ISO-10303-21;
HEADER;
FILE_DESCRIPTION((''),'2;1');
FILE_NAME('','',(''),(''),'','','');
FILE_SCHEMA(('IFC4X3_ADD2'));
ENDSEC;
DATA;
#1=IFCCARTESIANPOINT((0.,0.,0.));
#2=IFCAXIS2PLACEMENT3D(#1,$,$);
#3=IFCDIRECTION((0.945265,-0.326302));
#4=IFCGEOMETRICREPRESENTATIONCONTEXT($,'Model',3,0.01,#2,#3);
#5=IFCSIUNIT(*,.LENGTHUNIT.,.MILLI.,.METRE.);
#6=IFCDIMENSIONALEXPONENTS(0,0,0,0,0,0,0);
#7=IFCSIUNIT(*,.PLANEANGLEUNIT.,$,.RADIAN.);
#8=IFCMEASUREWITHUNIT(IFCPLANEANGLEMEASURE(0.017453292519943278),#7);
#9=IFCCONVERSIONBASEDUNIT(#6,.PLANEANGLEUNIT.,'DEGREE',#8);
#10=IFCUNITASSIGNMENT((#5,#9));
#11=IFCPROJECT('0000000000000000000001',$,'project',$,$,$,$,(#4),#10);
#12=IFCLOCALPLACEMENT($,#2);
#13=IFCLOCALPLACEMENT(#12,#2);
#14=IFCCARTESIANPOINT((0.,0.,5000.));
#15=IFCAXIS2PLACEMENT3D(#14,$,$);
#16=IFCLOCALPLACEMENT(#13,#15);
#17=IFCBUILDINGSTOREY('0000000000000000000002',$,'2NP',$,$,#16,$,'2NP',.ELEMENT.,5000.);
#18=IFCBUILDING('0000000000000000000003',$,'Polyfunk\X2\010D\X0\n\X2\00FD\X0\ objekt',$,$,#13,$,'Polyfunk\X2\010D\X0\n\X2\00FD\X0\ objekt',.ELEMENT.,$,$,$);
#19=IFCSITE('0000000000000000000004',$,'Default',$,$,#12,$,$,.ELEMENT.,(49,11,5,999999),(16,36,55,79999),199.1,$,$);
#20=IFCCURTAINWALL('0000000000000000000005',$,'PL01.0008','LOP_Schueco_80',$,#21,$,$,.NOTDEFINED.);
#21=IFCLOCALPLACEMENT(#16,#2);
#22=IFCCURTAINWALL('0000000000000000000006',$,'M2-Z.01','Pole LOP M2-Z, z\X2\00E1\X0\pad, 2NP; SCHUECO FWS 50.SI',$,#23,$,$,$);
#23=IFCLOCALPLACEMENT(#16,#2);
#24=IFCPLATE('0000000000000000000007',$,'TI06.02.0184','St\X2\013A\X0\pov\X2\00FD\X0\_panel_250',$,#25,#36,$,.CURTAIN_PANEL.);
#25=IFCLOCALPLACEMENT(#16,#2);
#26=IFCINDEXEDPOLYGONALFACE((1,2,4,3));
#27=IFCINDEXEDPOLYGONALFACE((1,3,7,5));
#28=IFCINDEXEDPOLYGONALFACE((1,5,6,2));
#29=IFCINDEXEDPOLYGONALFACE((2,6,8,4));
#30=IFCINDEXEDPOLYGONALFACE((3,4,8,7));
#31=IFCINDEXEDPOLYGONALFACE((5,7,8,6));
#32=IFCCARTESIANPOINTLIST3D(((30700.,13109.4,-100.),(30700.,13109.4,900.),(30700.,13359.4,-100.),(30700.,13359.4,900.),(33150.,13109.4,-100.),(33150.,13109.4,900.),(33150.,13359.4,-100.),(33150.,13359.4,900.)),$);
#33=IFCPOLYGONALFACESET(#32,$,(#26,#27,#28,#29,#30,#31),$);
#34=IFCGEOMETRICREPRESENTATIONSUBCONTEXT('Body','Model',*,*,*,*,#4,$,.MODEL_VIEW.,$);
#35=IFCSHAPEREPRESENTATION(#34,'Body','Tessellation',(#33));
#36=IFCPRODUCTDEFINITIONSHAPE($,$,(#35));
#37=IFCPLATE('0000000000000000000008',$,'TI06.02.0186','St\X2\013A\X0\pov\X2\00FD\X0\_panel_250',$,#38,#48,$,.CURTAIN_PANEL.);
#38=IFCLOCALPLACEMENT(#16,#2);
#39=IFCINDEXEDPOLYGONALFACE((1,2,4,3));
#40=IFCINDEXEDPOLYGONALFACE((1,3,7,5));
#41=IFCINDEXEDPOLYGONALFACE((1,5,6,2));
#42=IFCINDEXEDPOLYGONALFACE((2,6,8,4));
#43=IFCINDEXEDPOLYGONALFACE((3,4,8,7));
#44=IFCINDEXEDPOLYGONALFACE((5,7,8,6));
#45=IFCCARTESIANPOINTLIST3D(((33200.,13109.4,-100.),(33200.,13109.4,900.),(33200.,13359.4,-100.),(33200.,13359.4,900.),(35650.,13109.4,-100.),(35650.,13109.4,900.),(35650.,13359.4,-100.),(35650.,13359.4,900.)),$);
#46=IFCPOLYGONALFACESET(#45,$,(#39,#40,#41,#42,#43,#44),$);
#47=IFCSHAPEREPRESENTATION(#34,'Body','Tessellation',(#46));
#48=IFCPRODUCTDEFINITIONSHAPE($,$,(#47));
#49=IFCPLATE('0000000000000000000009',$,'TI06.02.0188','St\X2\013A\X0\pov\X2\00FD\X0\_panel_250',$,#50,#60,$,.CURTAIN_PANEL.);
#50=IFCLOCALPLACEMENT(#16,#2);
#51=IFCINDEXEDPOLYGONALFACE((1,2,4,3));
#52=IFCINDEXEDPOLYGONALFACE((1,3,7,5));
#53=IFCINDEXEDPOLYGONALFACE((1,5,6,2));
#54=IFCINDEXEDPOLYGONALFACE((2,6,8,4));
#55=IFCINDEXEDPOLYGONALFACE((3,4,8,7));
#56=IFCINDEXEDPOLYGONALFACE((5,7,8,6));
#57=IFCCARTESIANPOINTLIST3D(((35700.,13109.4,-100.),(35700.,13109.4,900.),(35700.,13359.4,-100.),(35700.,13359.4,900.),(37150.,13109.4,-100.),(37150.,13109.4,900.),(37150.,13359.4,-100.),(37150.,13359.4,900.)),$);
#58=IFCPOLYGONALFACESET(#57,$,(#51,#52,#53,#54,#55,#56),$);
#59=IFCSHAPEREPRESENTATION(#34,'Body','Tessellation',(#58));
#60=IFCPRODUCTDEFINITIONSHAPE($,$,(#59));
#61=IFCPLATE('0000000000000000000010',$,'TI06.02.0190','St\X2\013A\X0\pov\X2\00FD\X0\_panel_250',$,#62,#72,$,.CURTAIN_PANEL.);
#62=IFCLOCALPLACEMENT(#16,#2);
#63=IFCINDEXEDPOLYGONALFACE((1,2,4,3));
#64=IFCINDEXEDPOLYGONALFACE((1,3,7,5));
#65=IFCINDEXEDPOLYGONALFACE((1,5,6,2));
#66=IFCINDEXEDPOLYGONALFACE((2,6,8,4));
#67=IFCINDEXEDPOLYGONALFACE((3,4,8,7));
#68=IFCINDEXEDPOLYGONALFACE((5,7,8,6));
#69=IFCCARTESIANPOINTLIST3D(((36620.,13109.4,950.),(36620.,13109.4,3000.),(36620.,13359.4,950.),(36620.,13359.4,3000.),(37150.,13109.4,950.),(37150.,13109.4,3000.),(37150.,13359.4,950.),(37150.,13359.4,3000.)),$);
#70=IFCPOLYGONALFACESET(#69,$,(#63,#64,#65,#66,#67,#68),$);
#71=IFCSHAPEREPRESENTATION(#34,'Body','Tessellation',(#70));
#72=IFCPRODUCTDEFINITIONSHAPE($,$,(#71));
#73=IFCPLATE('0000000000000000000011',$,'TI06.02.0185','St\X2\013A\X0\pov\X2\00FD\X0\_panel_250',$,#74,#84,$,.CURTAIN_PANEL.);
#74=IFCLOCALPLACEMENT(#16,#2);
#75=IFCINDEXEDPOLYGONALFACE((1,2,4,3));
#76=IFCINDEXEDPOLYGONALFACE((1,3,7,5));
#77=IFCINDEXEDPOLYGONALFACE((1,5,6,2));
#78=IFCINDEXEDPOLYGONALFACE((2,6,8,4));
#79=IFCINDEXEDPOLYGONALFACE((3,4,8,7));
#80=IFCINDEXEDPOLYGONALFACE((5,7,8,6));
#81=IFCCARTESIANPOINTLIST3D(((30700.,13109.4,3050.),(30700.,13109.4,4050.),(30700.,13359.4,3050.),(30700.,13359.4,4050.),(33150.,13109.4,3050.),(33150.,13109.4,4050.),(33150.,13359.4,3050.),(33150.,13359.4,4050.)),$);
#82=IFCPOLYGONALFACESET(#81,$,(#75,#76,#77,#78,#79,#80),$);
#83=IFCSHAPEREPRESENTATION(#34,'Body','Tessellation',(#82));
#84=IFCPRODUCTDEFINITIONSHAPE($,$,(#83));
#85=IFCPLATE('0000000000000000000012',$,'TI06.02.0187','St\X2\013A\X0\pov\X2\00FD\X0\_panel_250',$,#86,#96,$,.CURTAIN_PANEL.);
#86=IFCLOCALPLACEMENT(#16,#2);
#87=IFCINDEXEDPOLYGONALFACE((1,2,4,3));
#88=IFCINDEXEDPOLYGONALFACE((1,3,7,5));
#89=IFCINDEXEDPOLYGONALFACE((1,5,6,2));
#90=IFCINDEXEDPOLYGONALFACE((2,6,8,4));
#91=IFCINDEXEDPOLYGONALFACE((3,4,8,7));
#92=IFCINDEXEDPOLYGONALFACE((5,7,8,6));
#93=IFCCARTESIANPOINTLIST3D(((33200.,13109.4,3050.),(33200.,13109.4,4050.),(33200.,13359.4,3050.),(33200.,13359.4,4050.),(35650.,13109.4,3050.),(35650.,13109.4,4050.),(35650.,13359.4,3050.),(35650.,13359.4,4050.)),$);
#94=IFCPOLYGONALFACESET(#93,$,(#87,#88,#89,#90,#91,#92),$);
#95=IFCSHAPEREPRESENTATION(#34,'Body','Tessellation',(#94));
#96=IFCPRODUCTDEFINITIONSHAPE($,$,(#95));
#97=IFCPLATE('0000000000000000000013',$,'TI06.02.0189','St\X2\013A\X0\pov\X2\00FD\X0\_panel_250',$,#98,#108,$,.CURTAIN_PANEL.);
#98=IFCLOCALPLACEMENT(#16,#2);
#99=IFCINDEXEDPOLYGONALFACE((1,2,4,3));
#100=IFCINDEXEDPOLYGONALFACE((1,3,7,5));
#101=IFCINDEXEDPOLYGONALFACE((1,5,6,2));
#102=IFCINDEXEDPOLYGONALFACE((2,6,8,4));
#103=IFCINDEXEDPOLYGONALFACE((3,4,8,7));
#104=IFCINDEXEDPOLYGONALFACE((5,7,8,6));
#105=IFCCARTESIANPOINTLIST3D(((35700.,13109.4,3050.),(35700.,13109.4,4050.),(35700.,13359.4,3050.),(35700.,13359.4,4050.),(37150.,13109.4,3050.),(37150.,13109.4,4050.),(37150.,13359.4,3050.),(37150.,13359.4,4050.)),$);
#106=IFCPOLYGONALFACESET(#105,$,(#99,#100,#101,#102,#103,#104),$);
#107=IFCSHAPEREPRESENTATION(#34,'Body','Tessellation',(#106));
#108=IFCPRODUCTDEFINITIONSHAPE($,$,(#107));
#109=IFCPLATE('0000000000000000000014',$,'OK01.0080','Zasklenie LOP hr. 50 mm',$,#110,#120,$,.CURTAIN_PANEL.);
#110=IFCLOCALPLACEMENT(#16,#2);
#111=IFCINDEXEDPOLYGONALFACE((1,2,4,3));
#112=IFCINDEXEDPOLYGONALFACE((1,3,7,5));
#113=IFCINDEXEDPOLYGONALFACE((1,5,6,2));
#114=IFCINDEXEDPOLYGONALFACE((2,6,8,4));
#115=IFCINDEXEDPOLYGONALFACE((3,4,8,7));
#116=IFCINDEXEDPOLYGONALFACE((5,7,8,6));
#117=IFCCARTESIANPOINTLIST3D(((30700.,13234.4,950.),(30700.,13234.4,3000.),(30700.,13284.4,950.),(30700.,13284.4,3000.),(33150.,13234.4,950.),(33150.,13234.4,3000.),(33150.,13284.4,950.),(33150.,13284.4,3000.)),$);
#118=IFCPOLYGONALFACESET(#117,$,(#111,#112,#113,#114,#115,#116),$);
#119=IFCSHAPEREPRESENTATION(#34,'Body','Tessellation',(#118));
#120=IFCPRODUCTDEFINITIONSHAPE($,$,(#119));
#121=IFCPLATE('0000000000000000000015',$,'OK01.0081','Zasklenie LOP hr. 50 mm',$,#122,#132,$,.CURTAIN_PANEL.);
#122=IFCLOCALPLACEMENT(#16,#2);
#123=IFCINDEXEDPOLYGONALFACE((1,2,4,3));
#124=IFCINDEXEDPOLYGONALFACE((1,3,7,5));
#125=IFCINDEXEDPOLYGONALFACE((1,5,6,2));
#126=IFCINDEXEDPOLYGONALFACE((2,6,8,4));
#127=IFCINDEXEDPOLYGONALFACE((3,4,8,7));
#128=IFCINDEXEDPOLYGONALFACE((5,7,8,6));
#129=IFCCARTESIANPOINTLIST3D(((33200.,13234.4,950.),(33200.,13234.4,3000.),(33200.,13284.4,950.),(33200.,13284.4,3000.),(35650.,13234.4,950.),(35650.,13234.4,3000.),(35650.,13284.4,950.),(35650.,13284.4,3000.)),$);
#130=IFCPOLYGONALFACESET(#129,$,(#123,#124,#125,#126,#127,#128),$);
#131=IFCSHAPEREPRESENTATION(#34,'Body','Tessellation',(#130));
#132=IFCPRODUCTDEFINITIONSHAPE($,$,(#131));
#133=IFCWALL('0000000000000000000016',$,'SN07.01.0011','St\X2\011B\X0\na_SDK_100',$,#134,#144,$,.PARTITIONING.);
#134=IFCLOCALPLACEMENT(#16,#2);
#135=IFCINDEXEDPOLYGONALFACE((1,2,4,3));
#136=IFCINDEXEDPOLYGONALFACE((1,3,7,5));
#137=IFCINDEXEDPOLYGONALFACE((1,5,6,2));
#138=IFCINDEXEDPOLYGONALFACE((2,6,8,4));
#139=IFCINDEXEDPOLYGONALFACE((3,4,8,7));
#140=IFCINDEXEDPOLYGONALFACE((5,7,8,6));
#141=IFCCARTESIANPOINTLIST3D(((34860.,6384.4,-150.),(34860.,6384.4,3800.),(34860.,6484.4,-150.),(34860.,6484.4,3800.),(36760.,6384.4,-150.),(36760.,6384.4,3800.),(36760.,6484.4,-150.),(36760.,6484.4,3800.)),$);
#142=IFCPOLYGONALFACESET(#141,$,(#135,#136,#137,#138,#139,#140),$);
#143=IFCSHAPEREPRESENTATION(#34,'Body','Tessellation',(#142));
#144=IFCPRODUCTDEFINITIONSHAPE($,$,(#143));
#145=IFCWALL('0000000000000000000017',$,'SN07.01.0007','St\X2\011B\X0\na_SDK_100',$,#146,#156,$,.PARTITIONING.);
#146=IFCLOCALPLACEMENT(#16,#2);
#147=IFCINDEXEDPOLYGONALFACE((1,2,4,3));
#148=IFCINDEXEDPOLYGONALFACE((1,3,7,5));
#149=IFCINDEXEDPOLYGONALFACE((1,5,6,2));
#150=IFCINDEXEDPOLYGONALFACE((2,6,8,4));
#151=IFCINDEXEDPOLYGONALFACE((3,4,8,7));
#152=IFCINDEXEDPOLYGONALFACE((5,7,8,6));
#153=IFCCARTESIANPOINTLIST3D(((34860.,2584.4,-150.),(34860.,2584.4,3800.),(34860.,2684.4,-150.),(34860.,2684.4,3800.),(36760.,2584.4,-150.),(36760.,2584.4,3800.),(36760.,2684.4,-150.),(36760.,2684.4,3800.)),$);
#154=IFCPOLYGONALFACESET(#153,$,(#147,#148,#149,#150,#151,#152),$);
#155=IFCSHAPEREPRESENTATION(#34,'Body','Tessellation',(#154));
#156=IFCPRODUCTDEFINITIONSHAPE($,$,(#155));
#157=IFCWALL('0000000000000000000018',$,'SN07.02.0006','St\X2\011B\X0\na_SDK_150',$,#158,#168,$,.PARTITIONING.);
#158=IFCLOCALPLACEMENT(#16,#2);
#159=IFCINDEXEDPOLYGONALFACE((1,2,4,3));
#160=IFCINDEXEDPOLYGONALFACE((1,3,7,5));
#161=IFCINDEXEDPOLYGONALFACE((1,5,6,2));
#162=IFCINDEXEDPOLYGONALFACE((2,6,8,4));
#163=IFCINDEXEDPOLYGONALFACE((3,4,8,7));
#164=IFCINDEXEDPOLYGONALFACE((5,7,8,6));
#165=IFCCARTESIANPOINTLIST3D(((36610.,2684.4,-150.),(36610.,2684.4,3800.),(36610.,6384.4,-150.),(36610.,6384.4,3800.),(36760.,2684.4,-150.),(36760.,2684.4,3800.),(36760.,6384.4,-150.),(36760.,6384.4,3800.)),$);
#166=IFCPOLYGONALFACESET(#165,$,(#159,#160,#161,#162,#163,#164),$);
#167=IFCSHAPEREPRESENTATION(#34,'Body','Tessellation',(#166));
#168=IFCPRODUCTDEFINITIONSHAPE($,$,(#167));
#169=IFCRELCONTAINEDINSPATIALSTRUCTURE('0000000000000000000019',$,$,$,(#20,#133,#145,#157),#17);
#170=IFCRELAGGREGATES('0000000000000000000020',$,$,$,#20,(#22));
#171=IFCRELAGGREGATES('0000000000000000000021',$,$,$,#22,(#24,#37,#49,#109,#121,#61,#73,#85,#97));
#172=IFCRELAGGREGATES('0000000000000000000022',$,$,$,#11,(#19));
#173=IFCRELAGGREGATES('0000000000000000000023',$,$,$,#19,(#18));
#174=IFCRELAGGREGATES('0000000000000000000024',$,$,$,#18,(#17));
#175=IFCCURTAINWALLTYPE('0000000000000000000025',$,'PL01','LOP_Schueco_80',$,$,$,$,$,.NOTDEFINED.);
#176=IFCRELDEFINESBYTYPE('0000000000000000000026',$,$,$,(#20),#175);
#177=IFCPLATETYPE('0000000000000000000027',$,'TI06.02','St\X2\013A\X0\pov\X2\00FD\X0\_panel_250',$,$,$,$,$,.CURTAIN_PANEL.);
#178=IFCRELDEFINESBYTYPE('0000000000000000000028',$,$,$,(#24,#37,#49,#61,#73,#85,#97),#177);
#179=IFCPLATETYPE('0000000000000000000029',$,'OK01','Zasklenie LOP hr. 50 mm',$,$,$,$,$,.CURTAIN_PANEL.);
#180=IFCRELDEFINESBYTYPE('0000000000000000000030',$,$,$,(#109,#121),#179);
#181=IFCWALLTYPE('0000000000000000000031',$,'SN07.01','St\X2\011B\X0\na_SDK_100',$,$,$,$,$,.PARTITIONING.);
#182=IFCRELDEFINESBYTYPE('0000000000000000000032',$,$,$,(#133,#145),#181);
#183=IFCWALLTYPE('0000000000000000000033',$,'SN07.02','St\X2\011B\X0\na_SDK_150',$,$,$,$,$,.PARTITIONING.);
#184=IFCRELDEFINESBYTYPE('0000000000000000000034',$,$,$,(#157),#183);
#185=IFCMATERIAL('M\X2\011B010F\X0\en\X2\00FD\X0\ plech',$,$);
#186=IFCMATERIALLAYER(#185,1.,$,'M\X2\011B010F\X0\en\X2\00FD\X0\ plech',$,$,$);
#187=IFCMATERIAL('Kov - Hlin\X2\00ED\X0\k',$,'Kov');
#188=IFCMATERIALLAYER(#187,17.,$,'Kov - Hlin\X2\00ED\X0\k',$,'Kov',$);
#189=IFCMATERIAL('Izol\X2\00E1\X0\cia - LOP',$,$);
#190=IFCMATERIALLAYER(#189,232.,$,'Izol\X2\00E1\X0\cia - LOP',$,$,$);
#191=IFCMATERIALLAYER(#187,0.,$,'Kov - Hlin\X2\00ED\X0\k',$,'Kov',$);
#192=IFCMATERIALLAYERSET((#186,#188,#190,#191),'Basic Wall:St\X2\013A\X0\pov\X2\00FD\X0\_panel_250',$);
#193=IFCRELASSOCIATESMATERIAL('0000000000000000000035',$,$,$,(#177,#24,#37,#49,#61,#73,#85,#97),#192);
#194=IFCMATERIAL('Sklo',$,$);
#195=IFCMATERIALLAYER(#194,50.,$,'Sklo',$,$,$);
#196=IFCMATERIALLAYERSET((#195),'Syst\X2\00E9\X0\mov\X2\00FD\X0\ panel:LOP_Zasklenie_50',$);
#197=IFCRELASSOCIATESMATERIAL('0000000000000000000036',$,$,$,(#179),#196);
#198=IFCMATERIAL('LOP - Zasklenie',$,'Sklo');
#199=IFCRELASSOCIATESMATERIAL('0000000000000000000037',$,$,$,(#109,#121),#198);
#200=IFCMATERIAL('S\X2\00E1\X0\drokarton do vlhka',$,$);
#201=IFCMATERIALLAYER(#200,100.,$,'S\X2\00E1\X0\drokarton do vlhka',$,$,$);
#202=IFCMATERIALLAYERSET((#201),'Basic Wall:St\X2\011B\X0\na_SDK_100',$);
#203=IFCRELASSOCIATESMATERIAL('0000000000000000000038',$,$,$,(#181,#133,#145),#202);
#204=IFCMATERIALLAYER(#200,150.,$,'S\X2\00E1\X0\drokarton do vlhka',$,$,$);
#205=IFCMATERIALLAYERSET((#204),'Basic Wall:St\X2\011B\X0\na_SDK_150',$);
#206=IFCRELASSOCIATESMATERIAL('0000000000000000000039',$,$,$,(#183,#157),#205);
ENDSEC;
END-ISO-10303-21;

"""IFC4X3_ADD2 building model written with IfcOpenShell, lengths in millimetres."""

from ifc_helpers import new_model, entity, si_unit, converted_unit, direction, frame, frame_2d, origin, origin_2d_with_axis, place, context, subcontext, project, spatial, polyline, rectangle, extrude, clip, bounded_halfspace, source, transform, mapped, material, layer, layer_set, layer_usage, type_object, type_shapes, element, aggregate, save


model = new_model("IFC4X3_ADD2")

# Units and contexts
model_context = context("Model", 3, precision=0.01, world=origin(), true_north=direction((0.945265, -0.326302)))
body_context = subcontext(model_context, "Body", "Model", "MODEL_VIEW")
ifc_project = project(units=[si_unit("LENGTHUNIT", "METRE", prefix="MILLI"), converted_unit("PLANEANGLEUNIT", "DEGREE", entity("IfcPlaneAngleMeasure", 0.017453292519943278), si_unit("PLANEANGLEUNIT", "RADIAN"), dimensions=[0, 0, 0, 0, 0, 0, 0])], contexts=[model_context])

# Site, building, storey
site_placement = place(None, origin())
site = spatial("IfcSite", under=ifc_project, at=site_placement, Name="Default", CompositionType="ELEMENT", RefLatitude=(49, 11, 5, 999999), RefLongitude=(16, 36, 55, 79999), RefElevation=199.1)
building_placement = place(site_placement, origin())
building = spatial("IfcBuilding", under=site, at=building_placement, Name="Polyfunkčný objekt", LongName="Polyfunkčný objekt", CompositionType="ELEMENT")
storey_placement = place(building_placement, frame((0.0, 0.0, 5000.0)))
storey = spatial("IfcBuildingStorey", under=building, at=storey_placement, Name="2NP", LongName="2NP", CompositionType="ELEMENT", Elevation=5000.0)

# Curtain walls, plates
curtain_wall_type = type_object("IfcCurtainWallType", Name="PL01", Description="LOP_Schueco_80", PredefinedType="NOTDEFINED")
curtain_wall_1_placement = place(storey_placement, frame((0.0, 0.0, -5000.0)))
curtain_wall_1 = element("IfcCurtainWall", 1, at=curtain_wall_1_placement, inside=storey, type_object=curtain_wall_type, Name="PL01.0008", Description="LOP_Schueco_80", PredefinedType="NOTDEFINED")
curtain_wall_2 = element("IfcCurtainWall", 2, Name="M2-Z.01", Description="Pole LOP M2-Z, západ, 2NP; SCHUECO FWS 50.SI")
aggregate(curtain_wall_1, [curtain_wall_2])
ifc_material_1 = material(Name="Měďený plech")
ifc_layer_1 = layer(ifc_material_1, 1.0, Name="Měďený plech")
ifc_material_2 = material(Name="Kov - Hliník", Category="Kov")
ifc_layer_2 = layer(ifc_material_2, 17.0, Name="Kov - Hliník", Category="Kov")
ifc_material_3 = material(Name="Izolácia - LOP")
ifc_layer_3 = layer(ifc_material_3, 232.0, Name="Izolácia - LOP")
ifc_layer_4 = layer(ifc_material_2, 0.0, Name="Kov - Hliník", Category="Kov")
ifc_layer_set_1 = layer_set([ifc_layer_1, ifc_layer_2, ifc_layer_3, ifc_layer_4], Name="Basic Wall:Stĺpový_panel_250")
ifc_layer_usage_1 = layer_usage(ifc_layer_set_1, "AXIS2", "NEGATIVE", 125.0)
plate_type_1 = type_object("IfcPlateType", Name="TI06.02", Description="Stĺpový_panel_250", PredefinedType="CURTAIN_PANEL", material=ifc_layer_set_1)
plate_1_placement = place(storey_placement, frame((30700.0, 13234.4, -100.0)))
plate_1 = element("IfcPlate", 3, at=plate_1_placement, type_object=plate_type_1, material=ifc_layer_usage_1, Name="TI06.02.0184", Description="Stĺpový_panel_250", PredefinedType="CURTAIN_PANEL", context=body_context, shape_type="SweptSolid", body=[
    extrude(rectangle(XDim=250.0, YDim=2450.0, at=frame_2d((0.0, 0.0), x_axis=(1.0, 0.0))), frame((1225.0, 0.0, 0.0), z_axis=(0.0, 0.0, 1.0), x_axis=(0.0, 1.0, 0.0)), (0.0, 0.0, 1.0), 1000.0),
])
ifc_layer_usage_2 = layer_usage(ifc_layer_set_1, "AXIS2", "NEGATIVE", 125.0)
plate_2_placement = place(storey_placement, frame((33200.0, 13234.4, -100.0)))
plate_2 = element("IfcPlate", 4, at=plate_2_placement, type_object=plate_type_1, material=ifc_layer_usage_2, Name="TI06.02.0186", Description="Stĺpový_panel_250", PredefinedType="CURTAIN_PANEL", context=body_context, shape_type="SweptSolid", body=[
    extrude(rectangle(XDim=250.0, YDim=2450.0, at=frame_2d((0.0, 0.0), x_axis=(1.0, 0.0))), frame((1225.0, 0.0, 0.0), z_axis=(0.0, 0.0, 1.0), x_axis=(0.0, 1.0, 0.0)), (0.0, 0.0, 1.0), 1000.0),
])
ifc_layer_usage_3 = layer_usage(ifc_layer_set_1, "AXIS2", "NEGATIVE", 125.0)
plate_3_placement = place(storey_placement, frame((35700.0, 13234.4, -100.0)))
plate_3 = element("IfcPlate", 5, at=plate_3_placement, type_object=plate_type_1, material=ifc_layer_usage_3, Name="TI06.02.0188", Description="Stĺpový_panel_250", PredefinedType="CURTAIN_PANEL", context=body_context, shape_type="SweptSolid", body=[
    extrude(rectangle(XDim=250.0, YDim=1450.0, at=origin_2d_with_axis()), frame((725.0, 0.0, 0.0), z_axis=(0.0, 0.0, 1.0), x_axis=(0.0, 1.0, 0.0)), (0.0, 0.0, 1.0), 1000.0),
])
ifc_layer_usage_4 = layer_usage(ifc_layer_set_1, "AXIS2", "NEGATIVE", 125.0)
plate_4_placement = place(storey_placement, frame((36620.0, 13234.4, 950.0)))
plate_4 = element("IfcPlate", 6, at=plate_4_placement, type_object=plate_type_1, material=ifc_layer_usage_4, Name="TI06.02.0190", Description="Stĺpový_panel_250", PredefinedType="CURTAIN_PANEL", context=body_context, shape_type="SweptSolid", body=[
    extrude(rectangle(XDim=250.0, YDim=530.0, at=frame_2d((0.0, 0.0), x_axis=(1.0, 0.0))), frame((265.0, 0.0, 0.0), z_axis=(0.0, 0.0, 1.0), x_axis=(0.0, 1.0, 0.0)), (0.0, 0.0, 1.0), 2050.0),
])
ifc_layer_usage_5 = layer_usage(ifc_layer_set_1, "AXIS2", "NEGATIVE", 125.0)
plate_5_placement = place(storey_placement, frame((30700.0, 13234.4, 3050.0)))
plate_5 = element("IfcPlate", 7, at=plate_5_placement, type_object=plate_type_1, material=ifc_layer_usage_5, Name="TI06.02.0185", Description="Stĺpový_panel_250", PredefinedType="CURTAIN_PANEL", context=body_context, shape_type="SweptSolid", body=[
    extrude(rectangle(XDim=250.0, YDim=2450.0, at=frame_2d((0.0, 0.0), x_axis=(1.0, 0.0))), frame((1225.0, 0.0, 0.0), z_axis=(0.0, 0.0, 1.0), x_axis=(0.0, 1.0, 0.0)), (0.0, 0.0, 1.0), 1000.0),
])
ifc_layer_usage_6 = layer_usage(ifc_layer_set_1, "AXIS2", "NEGATIVE", 125.0)
plate_6_placement = place(storey_placement, frame((33200.0, 13234.4, 3050.0)))
plate_6 = element("IfcPlate", 8, at=plate_6_placement, type_object=plate_type_1, material=ifc_layer_usage_6, Name="TI06.02.0187", Description="Stĺpový_panel_250", PredefinedType="CURTAIN_PANEL", context=body_context, shape_type="SweptSolid", body=[
    extrude(rectangle(XDim=250.0, YDim=2450.0, at=frame_2d((0.0, 0.0), x_axis=(1.0, 0.0))), frame((1225.0, 0.0, 0.0), z_axis=(0.0, 0.0, 1.0), x_axis=(0.0, 1.0, 0.0)), (0.0, 0.0, 1.0), 1000.0),
])
ifc_layer_usage_7 = layer_usage(ifc_layer_set_1, "AXIS2", "NEGATIVE", 125.0)
plate_7_placement = place(storey_placement, frame((35700.0, 13234.4, 3050.0)))
plate_7 = element("IfcPlate", 9, at=plate_7_placement, type_object=plate_type_1, material=ifc_layer_usage_7, Name="TI06.02.0189", Description="Stĺpový_panel_250", PredefinedType="CURTAIN_PANEL", context=body_context, shape_type="SweptSolid", body=[
    extrude(rectangle(XDim=250.0, YDim=1450.0, at=origin_2d_with_axis()), frame((725.0, 0.0, 0.0), z_axis=(0.0, 0.0, 1.0), x_axis=(0.0, 1.0, 0.0)), (0.0, 0.0, 1.0), 1000.0),
])
ifc_material_4 = material(Name="LOP - Zasklenie", Category="Sklo")
ifc_material_5 = material(Name="Sklo")
ifc_layer_5 = layer(ifc_material_5, 50.0, Name="Sklo")
ifc_layer_set_2 = layer_set([ifc_layer_5], Name="Systémový panel:LOP_Zasklenie_50")
plate_type_2 = type_object("IfcPlateType", Name="OK01", Description="Zasklenie LOP hr. 50 mm", PredefinedType="CURTAIN_PANEL", material=ifc_layer_set_2)
shared_shape_1 = source(origin(), body_context, "Body", "SweptSolid", [
    extrude(rectangle(XDim=50.0, YDim=2450.0, at=origin_2d_with_axis()), frame((0.0, 25.0, 0.0), z_axis=(0.0, 0.0, 1.0), x_axis=(0.0, 1.0, 0.0)), (0.0, 0.0, 1.0), 2050.0),
])
type_shapes(plate_type_2, [shared_shape_1])
plate_8_placement = place(curtain_wall_1_placement, frame((31925.0, 13234.4, 5950.0)))
plate_8 = element("IfcPlate", 10, at=plate_8_placement, type_object=plate_type_2, material=ifc_material_4, Name="OK01.0080", Description="Zasklenie LOP hr. 50 mm", PredefinedType="CURTAIN_PANEL", context=body_context, shape_type="MappedRepresentation", body=[
    mapped(shared_shape_1, transform((0.0, 0.0, 0.0), scale=1.0)),
])
plate_9_placement = place(curtain_wall_1_placement, frame((34425.0, 13234.4, 5950.0)))
plate_9 = element("IfcPlate", 11, at=plate_9_placement, type_object=plate_type_2, material=ifc_material_4, Name="OK01.0081", Description="Zasklenie LOP hr. 50 mm", PredefinedType="CURTAIN_PANEL", context=body_context, shape_type="MappedRepresentation", body=[
    mapped(shared_shape_1, transform((0.0, 0.0, 0.0), scale=1.0)),
])

# Walls
ifc_material_6 = material(Name="Sádrokarton do vlhka")
ifc_layer_6 = layer(ifc_material_6, 100.0, Name="Sádrokarton do vlhka")
ifc_layer_set_3 = layer_set([ifc_layer_6], Name="Basic Wall:Stěna_SDK_100")
wall_type_1 = type_object("IfcWallType", Name="SN07.01", Description="Stěna_SDK_100", PredefinedType="PARTITIONING", material=ifc_layer_set_3)
placement = place(building_placement, origin())
wall_1_placement = place(placement, frame((36760.0, 6434.4, 4850.0), z_axis=(0.0, 0.0, 1.0), x_axis=(-1.0, 0.0, 0.0)))
element("IfcWall", 12, at=wall_1_placement, inside=storey, type_object=wall_type_1, material=ifc_layer_set_3, Name="SN07.01.0011", Description="Stěna_SDK_100", PredefinedType="PARTITIONING", context=body_context, shape_type="Clipping", body=[
    clip(clip(extrude(rectangle(XDim=1900.0, YDim=100.0, at=frame_2d((950.0, 0.0), x_axis=(-1.0, 0.0))), origin(), (0.0, 0.0, 1.0), 3950.0), bounded_halfspace(frame((1900.0, -50.0, 0.0)), True, frame((1900.0, -50.0, 0.0)), polyline([(0.0, 0.0), (0.0, 100.0), (-1750.0, 100.0), (-1900.0, 100.0), (-1900.0, 0.0), (0.0, 0.0)]))), bounded_halfspace(frame((0.0, -50.0, 3950.0), z_axis=(0.0, 0.0, -1.0), x_axis=(-1.0, 0.0, 0.0)), True, frame((0.0, -50.0, 3950.0)), polyline([(0.0, 0.0), (1900.0, 0.0), (1900.0, 100.0), (150.0, 100.0), (0.0, 100.0), (0.0, 0.0)]))),
])
wall_2_placement = place(placement, frame((34860.0, 2634.4, 4850.0)))
element("IfcWall", 13, at=wall_2_placement, inside=storey, type_object=wall_type_1, material=ifc_layer_set_3, Name="SN07.01.0007", Description="Stěna_SDK_100", PredefinedType="PARTITIONING", context=body_context, shape_type="Clipping", body=[
    clip(clip(extrude(rectangle(XDim=1900.0, YDim=100.0, at=frame_2d((950.0, 0.0), x_axis=(-1.0, 0.0))), origin(), (0.0, 0.0, 1.0), 3950.0), bounded_halfspace(frame((1900.0, -50.0, 0.0), z_axis=(0.0, 0.0, 1.0), x_axis=(-1.0, 0.0, 0.0)), True, frame((1900.0, -50.0, 0.0)), polyline([(0.0, 0.0), (0.0, 100.0), (-150.0, 100.0), (-1900.0, 100.0), (-1900.0, 0.0), (-1800.0, 0.0), (0.0, 0.0)]))), bounded_halfspace(frame((0.0, -50.0, 3950.0), z_axis=(0.0, 0.0, -1.0), x_axis=(1.0, 0.0, 0.0)), True, frame((0.0, -50.0, 3950.0)), polyline([(0.0, 0.0), (100.0, 0.0), (1900.0, 0.0), (1900.0, 100.0), (1750.0, 100.0), (0.0, 100.0), (0.0, 0.0)]))),
])
ifc_layer_7 = layer(ifc_material_6, 150.0, Name="Sádrokarton do vlhka")
ifc_layer_set_4 = layer_set([ifc_layer_7], Name="Basic Wall:Stěna_SDK_150")
wall_type_2 = type_object("IfcWallType", Name="SN07.02", Description="Stěna_SDK_150", PredefinedType="PARTITIONING", material=ifc_layer_set_4)
wall_3_placement = place(placement, frame((36685.0, 6384.4, 4850.0), z_axis=(0.0, 0.0, 1.0), x_axis=(0.0, -1.0, 0.0)))
element("IfcWall", 14, at=wall_3_placement, inside=storey, type_object=wall_type_2, material=ifc_layer_set_4, Name="SN07.02.0006", Description="Stěna_SDK_150", PredefinedType="PARTITIONING", context=body_context, shape_type="SweptSolid", body=[
    extrude(rectangle(XDim=3700.0, YDim=150.0, at=frame_2d((1850.0, 0.0), x_axis=(-1.0, 0.0))), origin(), (0.0, 0.0, 1.0), 3950.0),
])

aggregate(curtain_wall_2, [plate_1, plate_2, plate_3, plate_8, plate_9, plate_4, plate_5, plate_6, plate_7])

save(model, "model.ifc")
